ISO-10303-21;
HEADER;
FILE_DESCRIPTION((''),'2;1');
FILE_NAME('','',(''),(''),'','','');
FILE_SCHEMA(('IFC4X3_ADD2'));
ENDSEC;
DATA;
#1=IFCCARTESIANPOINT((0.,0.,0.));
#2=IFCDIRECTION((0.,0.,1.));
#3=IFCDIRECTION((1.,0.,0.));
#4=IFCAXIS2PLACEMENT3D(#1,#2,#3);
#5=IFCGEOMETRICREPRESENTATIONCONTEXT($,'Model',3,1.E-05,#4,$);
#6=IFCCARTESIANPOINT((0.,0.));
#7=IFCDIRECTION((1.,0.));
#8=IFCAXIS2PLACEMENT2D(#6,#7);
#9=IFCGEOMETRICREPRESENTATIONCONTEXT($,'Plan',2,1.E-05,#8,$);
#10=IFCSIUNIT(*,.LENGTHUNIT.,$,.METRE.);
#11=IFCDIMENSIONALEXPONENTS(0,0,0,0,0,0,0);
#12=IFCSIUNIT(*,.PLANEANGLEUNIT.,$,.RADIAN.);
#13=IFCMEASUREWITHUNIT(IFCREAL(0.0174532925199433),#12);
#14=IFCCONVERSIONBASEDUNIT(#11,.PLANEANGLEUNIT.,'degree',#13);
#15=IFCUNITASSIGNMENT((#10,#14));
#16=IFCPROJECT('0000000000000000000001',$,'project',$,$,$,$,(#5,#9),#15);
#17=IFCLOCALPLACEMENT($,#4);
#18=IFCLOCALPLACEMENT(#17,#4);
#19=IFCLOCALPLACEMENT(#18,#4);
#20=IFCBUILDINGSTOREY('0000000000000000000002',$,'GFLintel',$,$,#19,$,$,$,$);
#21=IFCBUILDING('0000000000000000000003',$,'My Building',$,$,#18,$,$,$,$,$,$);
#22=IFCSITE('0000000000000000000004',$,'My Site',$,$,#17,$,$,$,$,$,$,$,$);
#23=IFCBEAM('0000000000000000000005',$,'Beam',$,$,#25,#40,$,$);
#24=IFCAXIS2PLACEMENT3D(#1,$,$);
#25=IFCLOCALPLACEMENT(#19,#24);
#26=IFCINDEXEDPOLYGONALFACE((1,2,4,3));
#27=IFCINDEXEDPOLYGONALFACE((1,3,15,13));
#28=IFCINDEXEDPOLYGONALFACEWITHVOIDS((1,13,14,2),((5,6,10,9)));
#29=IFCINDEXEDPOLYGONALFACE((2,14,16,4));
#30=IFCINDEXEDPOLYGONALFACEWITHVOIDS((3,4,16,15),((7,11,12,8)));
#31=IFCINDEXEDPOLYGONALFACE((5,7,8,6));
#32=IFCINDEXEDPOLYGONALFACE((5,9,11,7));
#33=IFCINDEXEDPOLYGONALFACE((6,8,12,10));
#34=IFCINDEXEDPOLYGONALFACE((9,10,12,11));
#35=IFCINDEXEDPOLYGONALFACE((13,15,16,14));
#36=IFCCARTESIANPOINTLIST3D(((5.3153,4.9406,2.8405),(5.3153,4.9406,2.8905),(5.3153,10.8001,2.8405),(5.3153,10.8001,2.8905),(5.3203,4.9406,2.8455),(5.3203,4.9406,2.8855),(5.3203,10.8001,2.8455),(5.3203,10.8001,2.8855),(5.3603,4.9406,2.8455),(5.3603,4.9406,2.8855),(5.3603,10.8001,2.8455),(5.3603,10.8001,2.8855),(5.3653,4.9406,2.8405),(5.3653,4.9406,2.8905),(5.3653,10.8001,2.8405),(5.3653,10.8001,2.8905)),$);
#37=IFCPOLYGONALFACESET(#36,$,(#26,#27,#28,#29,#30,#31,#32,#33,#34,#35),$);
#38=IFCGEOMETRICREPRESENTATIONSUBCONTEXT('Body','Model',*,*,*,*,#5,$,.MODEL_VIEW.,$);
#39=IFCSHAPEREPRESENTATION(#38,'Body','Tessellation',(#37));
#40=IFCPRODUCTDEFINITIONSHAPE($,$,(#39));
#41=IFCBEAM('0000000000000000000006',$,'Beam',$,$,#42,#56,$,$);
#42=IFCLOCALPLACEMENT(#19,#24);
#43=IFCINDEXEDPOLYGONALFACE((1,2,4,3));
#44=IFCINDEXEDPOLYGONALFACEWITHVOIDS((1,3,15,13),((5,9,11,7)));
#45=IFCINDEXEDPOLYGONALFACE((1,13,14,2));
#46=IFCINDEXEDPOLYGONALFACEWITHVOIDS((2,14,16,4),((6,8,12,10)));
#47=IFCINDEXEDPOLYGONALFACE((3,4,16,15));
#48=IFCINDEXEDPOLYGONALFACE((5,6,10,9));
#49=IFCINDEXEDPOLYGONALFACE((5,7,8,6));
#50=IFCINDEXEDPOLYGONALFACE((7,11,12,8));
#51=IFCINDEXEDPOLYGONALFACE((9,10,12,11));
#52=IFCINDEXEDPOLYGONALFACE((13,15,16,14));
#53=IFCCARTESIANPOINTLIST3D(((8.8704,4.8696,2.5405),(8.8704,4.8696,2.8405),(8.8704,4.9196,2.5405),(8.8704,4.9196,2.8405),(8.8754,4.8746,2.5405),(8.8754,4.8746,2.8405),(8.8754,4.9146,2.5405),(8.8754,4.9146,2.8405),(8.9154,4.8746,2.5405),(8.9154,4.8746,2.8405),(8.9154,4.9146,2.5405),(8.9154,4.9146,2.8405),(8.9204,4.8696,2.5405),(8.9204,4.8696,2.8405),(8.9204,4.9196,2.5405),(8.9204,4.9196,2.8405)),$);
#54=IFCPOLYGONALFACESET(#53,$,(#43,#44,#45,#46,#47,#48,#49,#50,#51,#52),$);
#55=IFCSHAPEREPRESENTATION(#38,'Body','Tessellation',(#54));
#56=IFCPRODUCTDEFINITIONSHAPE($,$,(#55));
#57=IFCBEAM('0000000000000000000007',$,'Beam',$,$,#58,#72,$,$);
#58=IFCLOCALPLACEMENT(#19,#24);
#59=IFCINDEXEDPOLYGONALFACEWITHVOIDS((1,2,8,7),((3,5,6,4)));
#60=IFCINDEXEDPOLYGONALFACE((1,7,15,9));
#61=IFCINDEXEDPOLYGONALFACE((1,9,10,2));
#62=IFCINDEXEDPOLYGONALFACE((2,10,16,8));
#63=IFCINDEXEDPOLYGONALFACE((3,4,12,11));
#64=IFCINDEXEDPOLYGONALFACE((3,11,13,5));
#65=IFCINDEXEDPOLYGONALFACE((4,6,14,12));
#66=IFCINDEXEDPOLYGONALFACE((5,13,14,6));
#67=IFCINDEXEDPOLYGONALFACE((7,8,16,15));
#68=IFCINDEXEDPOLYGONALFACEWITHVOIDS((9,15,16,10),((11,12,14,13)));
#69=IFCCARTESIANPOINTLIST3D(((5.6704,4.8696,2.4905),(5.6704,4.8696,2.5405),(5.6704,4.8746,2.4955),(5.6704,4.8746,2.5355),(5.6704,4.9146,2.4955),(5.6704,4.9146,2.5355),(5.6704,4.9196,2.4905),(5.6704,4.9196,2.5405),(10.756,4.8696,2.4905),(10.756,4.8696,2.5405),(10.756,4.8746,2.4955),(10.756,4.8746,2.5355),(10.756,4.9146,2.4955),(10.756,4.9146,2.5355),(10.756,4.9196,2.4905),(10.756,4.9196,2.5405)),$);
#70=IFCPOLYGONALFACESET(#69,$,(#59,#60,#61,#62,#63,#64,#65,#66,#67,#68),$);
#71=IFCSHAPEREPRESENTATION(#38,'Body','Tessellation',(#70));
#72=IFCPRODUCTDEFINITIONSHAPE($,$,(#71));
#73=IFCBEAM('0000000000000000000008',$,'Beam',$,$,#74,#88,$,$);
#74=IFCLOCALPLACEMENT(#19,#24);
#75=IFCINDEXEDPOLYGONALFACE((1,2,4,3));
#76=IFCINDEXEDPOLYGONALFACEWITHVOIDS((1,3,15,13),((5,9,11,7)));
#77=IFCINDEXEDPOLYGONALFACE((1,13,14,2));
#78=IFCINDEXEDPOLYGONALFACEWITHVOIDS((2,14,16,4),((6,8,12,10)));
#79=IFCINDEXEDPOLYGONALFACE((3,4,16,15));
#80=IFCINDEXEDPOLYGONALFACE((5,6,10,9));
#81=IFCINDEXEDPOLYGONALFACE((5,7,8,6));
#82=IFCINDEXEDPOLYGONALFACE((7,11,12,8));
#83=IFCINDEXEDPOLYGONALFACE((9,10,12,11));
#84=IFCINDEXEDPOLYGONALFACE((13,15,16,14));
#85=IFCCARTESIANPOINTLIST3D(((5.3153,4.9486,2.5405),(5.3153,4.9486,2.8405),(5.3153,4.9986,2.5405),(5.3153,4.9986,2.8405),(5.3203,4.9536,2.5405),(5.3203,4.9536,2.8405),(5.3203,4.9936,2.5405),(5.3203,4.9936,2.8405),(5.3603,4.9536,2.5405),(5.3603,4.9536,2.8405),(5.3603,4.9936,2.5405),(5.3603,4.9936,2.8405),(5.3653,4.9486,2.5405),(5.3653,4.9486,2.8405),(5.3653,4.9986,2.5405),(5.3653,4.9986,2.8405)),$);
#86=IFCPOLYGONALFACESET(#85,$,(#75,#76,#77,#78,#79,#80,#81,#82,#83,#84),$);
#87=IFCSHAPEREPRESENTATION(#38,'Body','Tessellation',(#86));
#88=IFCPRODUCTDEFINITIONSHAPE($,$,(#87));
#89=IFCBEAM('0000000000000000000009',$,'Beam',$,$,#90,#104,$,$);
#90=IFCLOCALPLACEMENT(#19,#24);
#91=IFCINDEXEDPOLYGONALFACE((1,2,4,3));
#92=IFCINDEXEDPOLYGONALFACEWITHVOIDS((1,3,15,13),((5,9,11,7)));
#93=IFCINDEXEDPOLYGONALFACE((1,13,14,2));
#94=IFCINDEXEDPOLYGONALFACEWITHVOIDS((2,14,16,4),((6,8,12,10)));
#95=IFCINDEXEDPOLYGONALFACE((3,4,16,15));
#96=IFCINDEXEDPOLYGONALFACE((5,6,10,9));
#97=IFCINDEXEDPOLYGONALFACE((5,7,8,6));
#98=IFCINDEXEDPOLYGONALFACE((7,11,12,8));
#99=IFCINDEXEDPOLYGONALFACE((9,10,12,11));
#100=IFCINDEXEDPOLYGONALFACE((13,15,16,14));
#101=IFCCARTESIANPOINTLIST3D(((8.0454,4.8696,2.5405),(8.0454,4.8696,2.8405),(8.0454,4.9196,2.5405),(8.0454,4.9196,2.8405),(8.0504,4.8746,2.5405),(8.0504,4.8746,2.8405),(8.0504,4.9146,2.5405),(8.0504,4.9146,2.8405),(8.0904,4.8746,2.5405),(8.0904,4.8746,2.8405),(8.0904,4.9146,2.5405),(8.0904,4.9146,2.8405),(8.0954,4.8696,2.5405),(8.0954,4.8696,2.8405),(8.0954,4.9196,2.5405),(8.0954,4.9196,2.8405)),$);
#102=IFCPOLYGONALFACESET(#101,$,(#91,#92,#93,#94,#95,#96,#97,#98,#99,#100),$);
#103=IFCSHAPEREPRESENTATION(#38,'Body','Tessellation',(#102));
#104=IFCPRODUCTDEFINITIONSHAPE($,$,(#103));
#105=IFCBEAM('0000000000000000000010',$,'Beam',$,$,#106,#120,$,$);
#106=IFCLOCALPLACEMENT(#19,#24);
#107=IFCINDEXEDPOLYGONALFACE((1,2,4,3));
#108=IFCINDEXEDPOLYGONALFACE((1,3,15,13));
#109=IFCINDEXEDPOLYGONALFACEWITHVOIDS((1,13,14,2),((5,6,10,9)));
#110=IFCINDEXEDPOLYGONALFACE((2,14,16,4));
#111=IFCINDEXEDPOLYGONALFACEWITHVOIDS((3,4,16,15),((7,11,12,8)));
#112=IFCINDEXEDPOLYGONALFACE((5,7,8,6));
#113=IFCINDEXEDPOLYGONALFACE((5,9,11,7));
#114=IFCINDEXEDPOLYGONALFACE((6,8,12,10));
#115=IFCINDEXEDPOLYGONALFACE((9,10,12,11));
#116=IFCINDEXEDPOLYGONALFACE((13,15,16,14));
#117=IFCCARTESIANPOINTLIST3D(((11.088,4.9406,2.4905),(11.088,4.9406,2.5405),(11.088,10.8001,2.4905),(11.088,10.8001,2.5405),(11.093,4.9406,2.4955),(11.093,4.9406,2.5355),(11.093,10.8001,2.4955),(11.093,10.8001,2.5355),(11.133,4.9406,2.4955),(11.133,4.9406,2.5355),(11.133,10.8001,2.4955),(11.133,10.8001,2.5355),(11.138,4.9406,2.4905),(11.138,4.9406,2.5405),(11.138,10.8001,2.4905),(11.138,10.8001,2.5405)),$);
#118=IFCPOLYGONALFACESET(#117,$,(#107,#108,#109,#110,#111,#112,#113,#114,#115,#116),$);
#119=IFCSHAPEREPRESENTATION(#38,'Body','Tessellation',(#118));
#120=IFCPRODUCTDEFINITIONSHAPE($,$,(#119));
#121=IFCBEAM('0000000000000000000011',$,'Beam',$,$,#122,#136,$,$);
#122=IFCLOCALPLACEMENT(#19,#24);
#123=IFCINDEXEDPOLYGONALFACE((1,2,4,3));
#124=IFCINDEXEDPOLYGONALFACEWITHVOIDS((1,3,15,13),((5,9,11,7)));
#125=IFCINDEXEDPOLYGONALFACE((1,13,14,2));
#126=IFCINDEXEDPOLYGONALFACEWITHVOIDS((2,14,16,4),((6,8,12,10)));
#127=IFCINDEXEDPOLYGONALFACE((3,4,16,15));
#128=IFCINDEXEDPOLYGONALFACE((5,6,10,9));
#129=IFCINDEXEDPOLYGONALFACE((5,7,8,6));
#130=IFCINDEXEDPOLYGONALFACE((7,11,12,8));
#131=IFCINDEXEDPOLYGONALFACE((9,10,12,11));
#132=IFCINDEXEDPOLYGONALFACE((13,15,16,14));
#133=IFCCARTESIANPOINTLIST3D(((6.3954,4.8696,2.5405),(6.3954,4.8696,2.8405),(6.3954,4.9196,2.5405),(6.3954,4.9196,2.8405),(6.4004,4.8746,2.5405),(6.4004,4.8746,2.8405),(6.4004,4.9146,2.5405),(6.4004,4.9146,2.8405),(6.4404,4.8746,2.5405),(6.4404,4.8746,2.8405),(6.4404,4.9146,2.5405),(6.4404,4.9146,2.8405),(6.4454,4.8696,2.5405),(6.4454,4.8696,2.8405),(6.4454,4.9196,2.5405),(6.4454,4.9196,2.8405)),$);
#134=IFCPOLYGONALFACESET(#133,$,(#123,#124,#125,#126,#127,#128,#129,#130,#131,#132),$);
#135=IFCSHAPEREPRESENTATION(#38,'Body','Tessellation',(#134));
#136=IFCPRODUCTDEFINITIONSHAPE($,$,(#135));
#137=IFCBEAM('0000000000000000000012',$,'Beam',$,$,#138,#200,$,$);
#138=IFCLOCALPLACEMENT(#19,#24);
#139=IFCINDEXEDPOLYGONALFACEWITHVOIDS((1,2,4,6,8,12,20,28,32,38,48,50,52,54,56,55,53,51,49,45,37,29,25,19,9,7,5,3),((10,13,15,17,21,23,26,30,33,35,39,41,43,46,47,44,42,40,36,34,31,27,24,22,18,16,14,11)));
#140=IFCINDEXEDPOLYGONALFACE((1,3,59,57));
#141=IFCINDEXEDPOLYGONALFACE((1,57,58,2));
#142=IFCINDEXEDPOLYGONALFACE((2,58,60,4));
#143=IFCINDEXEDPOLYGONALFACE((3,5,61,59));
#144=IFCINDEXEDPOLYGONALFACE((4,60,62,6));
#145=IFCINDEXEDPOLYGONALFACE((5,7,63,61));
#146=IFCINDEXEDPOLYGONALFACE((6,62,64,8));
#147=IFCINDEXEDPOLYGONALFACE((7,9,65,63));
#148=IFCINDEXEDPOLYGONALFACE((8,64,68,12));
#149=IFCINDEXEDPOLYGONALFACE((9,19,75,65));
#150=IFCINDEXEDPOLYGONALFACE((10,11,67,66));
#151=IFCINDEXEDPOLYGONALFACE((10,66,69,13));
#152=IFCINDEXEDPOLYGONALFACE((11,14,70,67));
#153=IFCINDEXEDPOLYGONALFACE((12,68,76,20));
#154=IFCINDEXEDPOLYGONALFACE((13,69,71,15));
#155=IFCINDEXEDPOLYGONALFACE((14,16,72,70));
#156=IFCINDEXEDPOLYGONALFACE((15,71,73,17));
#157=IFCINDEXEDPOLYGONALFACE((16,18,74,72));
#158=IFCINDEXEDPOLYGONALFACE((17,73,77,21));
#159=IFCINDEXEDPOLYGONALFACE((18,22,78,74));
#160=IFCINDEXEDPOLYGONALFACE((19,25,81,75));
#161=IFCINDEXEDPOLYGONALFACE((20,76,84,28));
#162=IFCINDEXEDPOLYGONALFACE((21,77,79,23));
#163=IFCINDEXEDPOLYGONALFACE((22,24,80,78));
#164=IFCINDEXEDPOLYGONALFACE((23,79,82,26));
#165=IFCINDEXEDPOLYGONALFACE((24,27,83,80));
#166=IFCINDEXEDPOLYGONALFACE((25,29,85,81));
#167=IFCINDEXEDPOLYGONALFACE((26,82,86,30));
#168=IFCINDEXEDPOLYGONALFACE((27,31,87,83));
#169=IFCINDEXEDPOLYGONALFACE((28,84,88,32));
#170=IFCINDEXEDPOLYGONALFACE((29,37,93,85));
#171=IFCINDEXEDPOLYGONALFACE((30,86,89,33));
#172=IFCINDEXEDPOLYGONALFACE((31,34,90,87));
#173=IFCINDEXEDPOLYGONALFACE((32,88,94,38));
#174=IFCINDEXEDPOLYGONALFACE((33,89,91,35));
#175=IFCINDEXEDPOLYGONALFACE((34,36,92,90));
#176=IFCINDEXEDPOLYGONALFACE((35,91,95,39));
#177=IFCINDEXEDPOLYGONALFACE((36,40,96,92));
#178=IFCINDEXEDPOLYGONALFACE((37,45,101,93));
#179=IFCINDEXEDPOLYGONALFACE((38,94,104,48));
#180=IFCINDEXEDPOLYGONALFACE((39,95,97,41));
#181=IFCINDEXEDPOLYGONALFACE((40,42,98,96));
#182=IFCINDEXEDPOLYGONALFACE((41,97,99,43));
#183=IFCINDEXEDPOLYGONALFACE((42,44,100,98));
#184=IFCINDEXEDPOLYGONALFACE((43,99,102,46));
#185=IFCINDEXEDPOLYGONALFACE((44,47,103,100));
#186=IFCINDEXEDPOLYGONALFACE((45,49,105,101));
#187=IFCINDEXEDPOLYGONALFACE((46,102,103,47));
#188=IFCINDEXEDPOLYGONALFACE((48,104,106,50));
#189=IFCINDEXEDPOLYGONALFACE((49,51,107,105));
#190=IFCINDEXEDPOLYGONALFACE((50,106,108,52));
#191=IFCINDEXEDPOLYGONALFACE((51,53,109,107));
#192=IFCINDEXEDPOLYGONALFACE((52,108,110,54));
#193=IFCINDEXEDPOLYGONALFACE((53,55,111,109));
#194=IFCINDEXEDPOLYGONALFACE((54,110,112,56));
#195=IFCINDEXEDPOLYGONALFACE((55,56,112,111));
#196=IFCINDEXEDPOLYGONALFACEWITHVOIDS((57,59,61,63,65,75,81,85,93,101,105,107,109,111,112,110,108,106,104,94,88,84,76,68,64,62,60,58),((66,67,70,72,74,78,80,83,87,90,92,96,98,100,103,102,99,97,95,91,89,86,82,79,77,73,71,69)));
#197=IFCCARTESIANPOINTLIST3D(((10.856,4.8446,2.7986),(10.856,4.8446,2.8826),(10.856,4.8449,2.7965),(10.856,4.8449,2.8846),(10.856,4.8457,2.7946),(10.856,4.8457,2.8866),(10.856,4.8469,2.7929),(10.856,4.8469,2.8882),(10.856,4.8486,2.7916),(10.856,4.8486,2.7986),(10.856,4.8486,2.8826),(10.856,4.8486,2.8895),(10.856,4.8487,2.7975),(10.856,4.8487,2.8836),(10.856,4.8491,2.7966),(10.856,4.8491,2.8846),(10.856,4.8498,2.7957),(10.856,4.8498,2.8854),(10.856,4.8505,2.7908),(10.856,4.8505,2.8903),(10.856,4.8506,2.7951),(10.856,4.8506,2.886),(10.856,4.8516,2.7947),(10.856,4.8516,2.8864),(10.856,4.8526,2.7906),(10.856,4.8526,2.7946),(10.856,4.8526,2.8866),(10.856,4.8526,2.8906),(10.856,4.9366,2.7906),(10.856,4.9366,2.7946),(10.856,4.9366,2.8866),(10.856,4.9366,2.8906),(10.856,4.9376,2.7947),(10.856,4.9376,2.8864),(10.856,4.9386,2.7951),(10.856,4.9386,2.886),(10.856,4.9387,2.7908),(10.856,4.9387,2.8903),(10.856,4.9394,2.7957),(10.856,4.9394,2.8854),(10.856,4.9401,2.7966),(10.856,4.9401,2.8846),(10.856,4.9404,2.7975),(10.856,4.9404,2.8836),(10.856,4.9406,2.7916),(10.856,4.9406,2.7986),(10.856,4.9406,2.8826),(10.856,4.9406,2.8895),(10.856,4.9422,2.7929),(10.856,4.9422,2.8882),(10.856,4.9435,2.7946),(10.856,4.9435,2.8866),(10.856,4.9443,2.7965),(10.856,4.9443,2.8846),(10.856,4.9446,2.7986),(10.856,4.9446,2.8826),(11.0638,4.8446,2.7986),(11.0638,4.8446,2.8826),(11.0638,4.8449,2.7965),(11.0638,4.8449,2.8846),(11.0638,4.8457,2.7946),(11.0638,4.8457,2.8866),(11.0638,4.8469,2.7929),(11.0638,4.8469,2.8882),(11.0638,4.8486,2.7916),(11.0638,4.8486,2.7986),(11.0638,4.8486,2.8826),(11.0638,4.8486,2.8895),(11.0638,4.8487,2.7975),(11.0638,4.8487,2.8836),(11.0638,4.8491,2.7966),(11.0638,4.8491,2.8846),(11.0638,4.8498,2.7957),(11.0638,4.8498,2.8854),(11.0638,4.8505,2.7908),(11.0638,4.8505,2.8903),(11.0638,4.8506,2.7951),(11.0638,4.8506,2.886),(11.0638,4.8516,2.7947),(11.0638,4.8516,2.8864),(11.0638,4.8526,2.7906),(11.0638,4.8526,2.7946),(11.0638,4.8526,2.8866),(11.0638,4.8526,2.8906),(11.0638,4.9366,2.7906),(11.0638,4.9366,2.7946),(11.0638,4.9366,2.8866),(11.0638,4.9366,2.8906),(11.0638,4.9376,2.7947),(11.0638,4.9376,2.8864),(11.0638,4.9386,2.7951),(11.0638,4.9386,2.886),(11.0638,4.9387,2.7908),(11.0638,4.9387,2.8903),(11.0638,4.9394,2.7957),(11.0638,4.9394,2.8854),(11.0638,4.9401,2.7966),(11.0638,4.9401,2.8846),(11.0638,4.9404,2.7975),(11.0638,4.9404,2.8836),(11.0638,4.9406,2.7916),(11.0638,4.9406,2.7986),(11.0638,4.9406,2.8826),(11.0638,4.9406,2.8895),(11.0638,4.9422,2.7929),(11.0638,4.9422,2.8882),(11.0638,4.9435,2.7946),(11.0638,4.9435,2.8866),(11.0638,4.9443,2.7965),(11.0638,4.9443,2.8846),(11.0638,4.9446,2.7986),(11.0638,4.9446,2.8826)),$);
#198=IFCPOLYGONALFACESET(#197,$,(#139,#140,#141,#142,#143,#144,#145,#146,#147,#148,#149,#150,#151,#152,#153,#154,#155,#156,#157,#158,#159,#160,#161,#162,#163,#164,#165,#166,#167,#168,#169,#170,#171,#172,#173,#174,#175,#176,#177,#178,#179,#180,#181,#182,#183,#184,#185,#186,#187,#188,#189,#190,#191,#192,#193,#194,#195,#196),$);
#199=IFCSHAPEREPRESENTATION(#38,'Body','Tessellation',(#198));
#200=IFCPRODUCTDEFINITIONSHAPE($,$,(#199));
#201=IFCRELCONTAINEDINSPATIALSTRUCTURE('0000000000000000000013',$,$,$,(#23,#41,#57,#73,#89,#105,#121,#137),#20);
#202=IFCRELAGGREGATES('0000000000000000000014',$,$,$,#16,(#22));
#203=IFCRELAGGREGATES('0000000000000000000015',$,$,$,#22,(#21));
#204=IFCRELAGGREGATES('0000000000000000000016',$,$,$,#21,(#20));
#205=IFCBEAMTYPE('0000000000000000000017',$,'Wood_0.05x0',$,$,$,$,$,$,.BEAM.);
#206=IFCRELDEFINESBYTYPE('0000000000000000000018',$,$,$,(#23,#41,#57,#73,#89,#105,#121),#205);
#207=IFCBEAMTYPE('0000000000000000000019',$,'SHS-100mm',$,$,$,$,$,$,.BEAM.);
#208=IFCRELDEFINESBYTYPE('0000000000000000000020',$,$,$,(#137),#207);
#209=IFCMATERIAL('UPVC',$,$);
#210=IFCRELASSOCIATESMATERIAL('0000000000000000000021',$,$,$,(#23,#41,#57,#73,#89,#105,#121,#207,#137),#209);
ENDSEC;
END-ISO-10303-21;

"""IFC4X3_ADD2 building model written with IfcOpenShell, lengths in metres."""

from ifc_helpers import new_model, entity, si_unit, converted_unit, frame, origin_with_axes, origin_2d_with_axis, place, context, subcontext, project, spatial, hollow_rectangle, extrude, material, material_profile, profile_set, profile_usage, type_object, element, save


model = new_model("IFC4X3_ADD2")

# Units and contexts
model_context = context("Model", 3, precision=1e-05, world=origin_with_axes())
plan_context = context("Plan", 2, precision=1e-05, world=origin_2d_with_axis())
body_context = subcontext(model_context, "Body", "Model", "MODEL_VIEW")
ifc_project = project(units=[si_unit("LENGTHUNIT", "METRE"), converted_unit("PLANEANGLEUNIT", "degree", entity("IfcReal", 0.0174532925199433), si_unit("PLANEANGLEUNIT", "RADIAN"), dimensions=[0, 0, 0, 0, 0, 0, 0])], contexts=[model_context, plan_context])

# Site, building, storey
site_placement = place(None, origin_with_axes())
site = spatial("IfcSite", under=ifc_project, at=site_placement, Name="My Site")
building_placement = place(site_placement, origin_with_axes())
building = spatial("IfcBuilding", under=site, at=building_placement, Name="My Building")
storey_placement = place(building_placement, origin_with_axes())
storey = spatial("IfcBuildingStorey", under=building, at=storey_placement, Name="GFLintel")

# Beams
ifc_material_1 = material(Name="UPVC")
ifc_material_profile_1 = material_profile(ifc_material_1, hollow_rectangle(XDim=0.05, YDim=0.05, WallThickness=0.005))
ifc_profile_set_1 = profile_set([ifc_material_profile_1])
beam_type_1 = type_object("IfcBeamType", Name="Wood_0.05x0", PredefinedType="BEAM")
ifc_profile_usage_1 = profile_usage(ifc_profile_set_1, cardinal=5)
beam_1_placement = place(storey_placement, frame((5.3403, 4.9406, 2.8655), z_axis=(0.0, 1.0, 0.000001), x_axis=(-1.0, 0.0, 0.0)))
element("IfcBeam", 1, at=beam_1_placement, inside=storey, type_object=beam_type_1, material=ifc_profile_usage_1, Name="Beam", context=body_context, shape_type="SweptSolid", body=[
    extrude(hollow_rectangle(XDim=0.05, YDim=0.05, WallThickness=0.005), origin_with_axes(), (0.0, 0.0, 1.0), 5.8595),
])
ifc_profile_usage_2 = profile_usage(ifc_profile_set_1, cardinal=5)
beam_2_placement = place(storey_placement, frame((8.8954, 4.8946, 2.5405), z_axis=(-0.000001, 0.0, 1.0), x_axis=(0.0, 1.0, 0.0)))
element("IfcBeam", 2, at=beam_2_placement, inside=storey, type_object=beam_type_1, material=ifc_profile_usage_2, Name="Beam", context=body_context, shape_type="SweptSolid", body=[
    extrude(hollow_rectangle(XDim=0.05, YDim=0.05, WallThickness=0.005), origin_with_axes(), (0.0, 0.0, 1.0), 0.3),
])
ifc_profile_usage_3 = profile_usage(ifc_profile_set_1, cardinal=5)
beam_3_placement = place(storey_placement, frame((5.6704, 4.8946, 2.5155), z_axis=(1.0, 0.0, 0.000001), x_axis=(0.0, 1.0, 0.0)))
element("IfcBeam", 3, at=beam_3_placement, inside=storey, type_object=beam_type_1, material=ifc_profile_usage_3, Name="Beam", context=body_context, shape_type="SweptSolid", body=[
    extrude(hollow_rectangle(XDim=0.05, YDim=0.05, WallThickness=0.005), origin_with_axes(), (0.0, 0.0, 1.0), 5.0856),
])
ifc_profile_usage_4 = profile_usage(ifc_profile_set_1, cardinal=5)
beam_4_placement = place(storey_placement, frame((5.3403, 4.9736, 2.5405), z_axis=(0.0, -0.000001, 1.0), x_axis=(-1.0, 0.0, 0.0)))
element("IfcBeam", 4, at=beam_4_placement, inside=storey, type_object=beam_type_1, material=ifc_profile_usage_4, Name="Beam", context=body_context, shape_type="SweptSolid", body=[
    extrude(hollow_rectangle(XDim=0.05, YDim=0.05, WallThickness=0.005), origin_with_axes(), (0.0, 0.0, 1.0), 0.3),
])
ifc_profile_usage_5 = profile_usage(ifc_profile_set_1, cardinal=5)
beam_5_placement = place(storey_placement, frame((8.0704, 4.8946, 2.5405), z_axis=(-0.000001, 0.0, 1.0), x_axis=(0.0, 1.0, 0.0)))
element("IfcBeam", 5, at=beam_5_placement, inside=storey, type_object=beam_type_1, material=ifc_profile_usage_5, Name="Beam", context=body_context, shape_type="SweptSolid", body=[
    extrude(hollow_rectangle(XDim=0.05, YDim=0.05, WallThickness=0.005), origin_with_axes(), (0.0, 0.0, 1.0), 0.3),
])
ifc_profile_usage_6 = profile_usage(ifc_profile_set_1, cardinal=5)
beam_6_placement = place(storey_placement, frame((11.113, 4.9406, 2.5155), z_axis=(0.0, 1.0, 0.000001), x_axis=(-1.0, 0.0, 0.0)))
element("IfcBeam", 6, at=beam_6_placement, inside=storey, type_object=beam_type_1, material=ifc_profile_usage_6, Name="Beam", context=body_context, shape_type="SweptSolid", body=[
    extrude(hollow_rectangle(XDim=0.05, YDim=0.05, WallThickness=0.005), origin_with_axes(), (0.0, 0.0, 1.0), 5.8595),
])
ifc_profile_usage_7 = profile_usage(ifc_profile_set_1, cardinal=5)
beam_7_placement = place(storey_placement, frame((6.4204, 4.8946, 2.5405), z_axis=(-0.000001, 0.0, 1.0), x_axis=(0.0, 1.0, 0.0)))
element("IfcBeam", 7, at=beam_7_placement, inside=storey, type_object=beam_type_1, material=ifc_profile_usage_7, Name="Beam", context=body_context, shape_type="SweptSolid", body=[
    extrude(hollow_rectangle(XDim=0.05, YDim=0.05, WallThickness=0.005), origin_with_axes(), (0.0, 0.0, 1.0), 0.3),
])
ifc_material_profile_2 = material_profile(ifc_material_1, hollow_rectangle(XDim=0.1, YDim=0.1, WallThickness=0.004, InnerFilletRadius=0.004, OuterFilletRadius=0.008))
ifc_profile_set_2 = profile_set([ifc_material_profile_2])
ifc_profile_usage_8 = profile_usage(ifc_profile_set_2, cardinal=5)
beam_type_2 = type_object("IfcBeamType", Name="SHS-100mm", PredefinedType="BEAM", material=ifc_profile_set_2)
beam_8_placement = place(storey_placement, frame((10.856, 4.8946, 2.8406), z_axis=(1.0, 0.0, 0.000001), x_axis=(0.0, 1.0, 0.0)))
element("IfcBeam", 8, at=beam_8_placement, inside=storey, type_object=beam_type_2, material=ifc_profile_usage_8, Name="Beam", context=body_context, shape_type="SweptSolid", body=[
    extrude(hollow_rectangle(XDim=0.1, YDim=0.1, WallThickness=0.004, InnerFilletRadius=0.004, OuterFilletRadius=0.008), origin_with_axes(), (0.0, 0.0, 1.0), 0.2078),
])

save(model, "model.ifc")
